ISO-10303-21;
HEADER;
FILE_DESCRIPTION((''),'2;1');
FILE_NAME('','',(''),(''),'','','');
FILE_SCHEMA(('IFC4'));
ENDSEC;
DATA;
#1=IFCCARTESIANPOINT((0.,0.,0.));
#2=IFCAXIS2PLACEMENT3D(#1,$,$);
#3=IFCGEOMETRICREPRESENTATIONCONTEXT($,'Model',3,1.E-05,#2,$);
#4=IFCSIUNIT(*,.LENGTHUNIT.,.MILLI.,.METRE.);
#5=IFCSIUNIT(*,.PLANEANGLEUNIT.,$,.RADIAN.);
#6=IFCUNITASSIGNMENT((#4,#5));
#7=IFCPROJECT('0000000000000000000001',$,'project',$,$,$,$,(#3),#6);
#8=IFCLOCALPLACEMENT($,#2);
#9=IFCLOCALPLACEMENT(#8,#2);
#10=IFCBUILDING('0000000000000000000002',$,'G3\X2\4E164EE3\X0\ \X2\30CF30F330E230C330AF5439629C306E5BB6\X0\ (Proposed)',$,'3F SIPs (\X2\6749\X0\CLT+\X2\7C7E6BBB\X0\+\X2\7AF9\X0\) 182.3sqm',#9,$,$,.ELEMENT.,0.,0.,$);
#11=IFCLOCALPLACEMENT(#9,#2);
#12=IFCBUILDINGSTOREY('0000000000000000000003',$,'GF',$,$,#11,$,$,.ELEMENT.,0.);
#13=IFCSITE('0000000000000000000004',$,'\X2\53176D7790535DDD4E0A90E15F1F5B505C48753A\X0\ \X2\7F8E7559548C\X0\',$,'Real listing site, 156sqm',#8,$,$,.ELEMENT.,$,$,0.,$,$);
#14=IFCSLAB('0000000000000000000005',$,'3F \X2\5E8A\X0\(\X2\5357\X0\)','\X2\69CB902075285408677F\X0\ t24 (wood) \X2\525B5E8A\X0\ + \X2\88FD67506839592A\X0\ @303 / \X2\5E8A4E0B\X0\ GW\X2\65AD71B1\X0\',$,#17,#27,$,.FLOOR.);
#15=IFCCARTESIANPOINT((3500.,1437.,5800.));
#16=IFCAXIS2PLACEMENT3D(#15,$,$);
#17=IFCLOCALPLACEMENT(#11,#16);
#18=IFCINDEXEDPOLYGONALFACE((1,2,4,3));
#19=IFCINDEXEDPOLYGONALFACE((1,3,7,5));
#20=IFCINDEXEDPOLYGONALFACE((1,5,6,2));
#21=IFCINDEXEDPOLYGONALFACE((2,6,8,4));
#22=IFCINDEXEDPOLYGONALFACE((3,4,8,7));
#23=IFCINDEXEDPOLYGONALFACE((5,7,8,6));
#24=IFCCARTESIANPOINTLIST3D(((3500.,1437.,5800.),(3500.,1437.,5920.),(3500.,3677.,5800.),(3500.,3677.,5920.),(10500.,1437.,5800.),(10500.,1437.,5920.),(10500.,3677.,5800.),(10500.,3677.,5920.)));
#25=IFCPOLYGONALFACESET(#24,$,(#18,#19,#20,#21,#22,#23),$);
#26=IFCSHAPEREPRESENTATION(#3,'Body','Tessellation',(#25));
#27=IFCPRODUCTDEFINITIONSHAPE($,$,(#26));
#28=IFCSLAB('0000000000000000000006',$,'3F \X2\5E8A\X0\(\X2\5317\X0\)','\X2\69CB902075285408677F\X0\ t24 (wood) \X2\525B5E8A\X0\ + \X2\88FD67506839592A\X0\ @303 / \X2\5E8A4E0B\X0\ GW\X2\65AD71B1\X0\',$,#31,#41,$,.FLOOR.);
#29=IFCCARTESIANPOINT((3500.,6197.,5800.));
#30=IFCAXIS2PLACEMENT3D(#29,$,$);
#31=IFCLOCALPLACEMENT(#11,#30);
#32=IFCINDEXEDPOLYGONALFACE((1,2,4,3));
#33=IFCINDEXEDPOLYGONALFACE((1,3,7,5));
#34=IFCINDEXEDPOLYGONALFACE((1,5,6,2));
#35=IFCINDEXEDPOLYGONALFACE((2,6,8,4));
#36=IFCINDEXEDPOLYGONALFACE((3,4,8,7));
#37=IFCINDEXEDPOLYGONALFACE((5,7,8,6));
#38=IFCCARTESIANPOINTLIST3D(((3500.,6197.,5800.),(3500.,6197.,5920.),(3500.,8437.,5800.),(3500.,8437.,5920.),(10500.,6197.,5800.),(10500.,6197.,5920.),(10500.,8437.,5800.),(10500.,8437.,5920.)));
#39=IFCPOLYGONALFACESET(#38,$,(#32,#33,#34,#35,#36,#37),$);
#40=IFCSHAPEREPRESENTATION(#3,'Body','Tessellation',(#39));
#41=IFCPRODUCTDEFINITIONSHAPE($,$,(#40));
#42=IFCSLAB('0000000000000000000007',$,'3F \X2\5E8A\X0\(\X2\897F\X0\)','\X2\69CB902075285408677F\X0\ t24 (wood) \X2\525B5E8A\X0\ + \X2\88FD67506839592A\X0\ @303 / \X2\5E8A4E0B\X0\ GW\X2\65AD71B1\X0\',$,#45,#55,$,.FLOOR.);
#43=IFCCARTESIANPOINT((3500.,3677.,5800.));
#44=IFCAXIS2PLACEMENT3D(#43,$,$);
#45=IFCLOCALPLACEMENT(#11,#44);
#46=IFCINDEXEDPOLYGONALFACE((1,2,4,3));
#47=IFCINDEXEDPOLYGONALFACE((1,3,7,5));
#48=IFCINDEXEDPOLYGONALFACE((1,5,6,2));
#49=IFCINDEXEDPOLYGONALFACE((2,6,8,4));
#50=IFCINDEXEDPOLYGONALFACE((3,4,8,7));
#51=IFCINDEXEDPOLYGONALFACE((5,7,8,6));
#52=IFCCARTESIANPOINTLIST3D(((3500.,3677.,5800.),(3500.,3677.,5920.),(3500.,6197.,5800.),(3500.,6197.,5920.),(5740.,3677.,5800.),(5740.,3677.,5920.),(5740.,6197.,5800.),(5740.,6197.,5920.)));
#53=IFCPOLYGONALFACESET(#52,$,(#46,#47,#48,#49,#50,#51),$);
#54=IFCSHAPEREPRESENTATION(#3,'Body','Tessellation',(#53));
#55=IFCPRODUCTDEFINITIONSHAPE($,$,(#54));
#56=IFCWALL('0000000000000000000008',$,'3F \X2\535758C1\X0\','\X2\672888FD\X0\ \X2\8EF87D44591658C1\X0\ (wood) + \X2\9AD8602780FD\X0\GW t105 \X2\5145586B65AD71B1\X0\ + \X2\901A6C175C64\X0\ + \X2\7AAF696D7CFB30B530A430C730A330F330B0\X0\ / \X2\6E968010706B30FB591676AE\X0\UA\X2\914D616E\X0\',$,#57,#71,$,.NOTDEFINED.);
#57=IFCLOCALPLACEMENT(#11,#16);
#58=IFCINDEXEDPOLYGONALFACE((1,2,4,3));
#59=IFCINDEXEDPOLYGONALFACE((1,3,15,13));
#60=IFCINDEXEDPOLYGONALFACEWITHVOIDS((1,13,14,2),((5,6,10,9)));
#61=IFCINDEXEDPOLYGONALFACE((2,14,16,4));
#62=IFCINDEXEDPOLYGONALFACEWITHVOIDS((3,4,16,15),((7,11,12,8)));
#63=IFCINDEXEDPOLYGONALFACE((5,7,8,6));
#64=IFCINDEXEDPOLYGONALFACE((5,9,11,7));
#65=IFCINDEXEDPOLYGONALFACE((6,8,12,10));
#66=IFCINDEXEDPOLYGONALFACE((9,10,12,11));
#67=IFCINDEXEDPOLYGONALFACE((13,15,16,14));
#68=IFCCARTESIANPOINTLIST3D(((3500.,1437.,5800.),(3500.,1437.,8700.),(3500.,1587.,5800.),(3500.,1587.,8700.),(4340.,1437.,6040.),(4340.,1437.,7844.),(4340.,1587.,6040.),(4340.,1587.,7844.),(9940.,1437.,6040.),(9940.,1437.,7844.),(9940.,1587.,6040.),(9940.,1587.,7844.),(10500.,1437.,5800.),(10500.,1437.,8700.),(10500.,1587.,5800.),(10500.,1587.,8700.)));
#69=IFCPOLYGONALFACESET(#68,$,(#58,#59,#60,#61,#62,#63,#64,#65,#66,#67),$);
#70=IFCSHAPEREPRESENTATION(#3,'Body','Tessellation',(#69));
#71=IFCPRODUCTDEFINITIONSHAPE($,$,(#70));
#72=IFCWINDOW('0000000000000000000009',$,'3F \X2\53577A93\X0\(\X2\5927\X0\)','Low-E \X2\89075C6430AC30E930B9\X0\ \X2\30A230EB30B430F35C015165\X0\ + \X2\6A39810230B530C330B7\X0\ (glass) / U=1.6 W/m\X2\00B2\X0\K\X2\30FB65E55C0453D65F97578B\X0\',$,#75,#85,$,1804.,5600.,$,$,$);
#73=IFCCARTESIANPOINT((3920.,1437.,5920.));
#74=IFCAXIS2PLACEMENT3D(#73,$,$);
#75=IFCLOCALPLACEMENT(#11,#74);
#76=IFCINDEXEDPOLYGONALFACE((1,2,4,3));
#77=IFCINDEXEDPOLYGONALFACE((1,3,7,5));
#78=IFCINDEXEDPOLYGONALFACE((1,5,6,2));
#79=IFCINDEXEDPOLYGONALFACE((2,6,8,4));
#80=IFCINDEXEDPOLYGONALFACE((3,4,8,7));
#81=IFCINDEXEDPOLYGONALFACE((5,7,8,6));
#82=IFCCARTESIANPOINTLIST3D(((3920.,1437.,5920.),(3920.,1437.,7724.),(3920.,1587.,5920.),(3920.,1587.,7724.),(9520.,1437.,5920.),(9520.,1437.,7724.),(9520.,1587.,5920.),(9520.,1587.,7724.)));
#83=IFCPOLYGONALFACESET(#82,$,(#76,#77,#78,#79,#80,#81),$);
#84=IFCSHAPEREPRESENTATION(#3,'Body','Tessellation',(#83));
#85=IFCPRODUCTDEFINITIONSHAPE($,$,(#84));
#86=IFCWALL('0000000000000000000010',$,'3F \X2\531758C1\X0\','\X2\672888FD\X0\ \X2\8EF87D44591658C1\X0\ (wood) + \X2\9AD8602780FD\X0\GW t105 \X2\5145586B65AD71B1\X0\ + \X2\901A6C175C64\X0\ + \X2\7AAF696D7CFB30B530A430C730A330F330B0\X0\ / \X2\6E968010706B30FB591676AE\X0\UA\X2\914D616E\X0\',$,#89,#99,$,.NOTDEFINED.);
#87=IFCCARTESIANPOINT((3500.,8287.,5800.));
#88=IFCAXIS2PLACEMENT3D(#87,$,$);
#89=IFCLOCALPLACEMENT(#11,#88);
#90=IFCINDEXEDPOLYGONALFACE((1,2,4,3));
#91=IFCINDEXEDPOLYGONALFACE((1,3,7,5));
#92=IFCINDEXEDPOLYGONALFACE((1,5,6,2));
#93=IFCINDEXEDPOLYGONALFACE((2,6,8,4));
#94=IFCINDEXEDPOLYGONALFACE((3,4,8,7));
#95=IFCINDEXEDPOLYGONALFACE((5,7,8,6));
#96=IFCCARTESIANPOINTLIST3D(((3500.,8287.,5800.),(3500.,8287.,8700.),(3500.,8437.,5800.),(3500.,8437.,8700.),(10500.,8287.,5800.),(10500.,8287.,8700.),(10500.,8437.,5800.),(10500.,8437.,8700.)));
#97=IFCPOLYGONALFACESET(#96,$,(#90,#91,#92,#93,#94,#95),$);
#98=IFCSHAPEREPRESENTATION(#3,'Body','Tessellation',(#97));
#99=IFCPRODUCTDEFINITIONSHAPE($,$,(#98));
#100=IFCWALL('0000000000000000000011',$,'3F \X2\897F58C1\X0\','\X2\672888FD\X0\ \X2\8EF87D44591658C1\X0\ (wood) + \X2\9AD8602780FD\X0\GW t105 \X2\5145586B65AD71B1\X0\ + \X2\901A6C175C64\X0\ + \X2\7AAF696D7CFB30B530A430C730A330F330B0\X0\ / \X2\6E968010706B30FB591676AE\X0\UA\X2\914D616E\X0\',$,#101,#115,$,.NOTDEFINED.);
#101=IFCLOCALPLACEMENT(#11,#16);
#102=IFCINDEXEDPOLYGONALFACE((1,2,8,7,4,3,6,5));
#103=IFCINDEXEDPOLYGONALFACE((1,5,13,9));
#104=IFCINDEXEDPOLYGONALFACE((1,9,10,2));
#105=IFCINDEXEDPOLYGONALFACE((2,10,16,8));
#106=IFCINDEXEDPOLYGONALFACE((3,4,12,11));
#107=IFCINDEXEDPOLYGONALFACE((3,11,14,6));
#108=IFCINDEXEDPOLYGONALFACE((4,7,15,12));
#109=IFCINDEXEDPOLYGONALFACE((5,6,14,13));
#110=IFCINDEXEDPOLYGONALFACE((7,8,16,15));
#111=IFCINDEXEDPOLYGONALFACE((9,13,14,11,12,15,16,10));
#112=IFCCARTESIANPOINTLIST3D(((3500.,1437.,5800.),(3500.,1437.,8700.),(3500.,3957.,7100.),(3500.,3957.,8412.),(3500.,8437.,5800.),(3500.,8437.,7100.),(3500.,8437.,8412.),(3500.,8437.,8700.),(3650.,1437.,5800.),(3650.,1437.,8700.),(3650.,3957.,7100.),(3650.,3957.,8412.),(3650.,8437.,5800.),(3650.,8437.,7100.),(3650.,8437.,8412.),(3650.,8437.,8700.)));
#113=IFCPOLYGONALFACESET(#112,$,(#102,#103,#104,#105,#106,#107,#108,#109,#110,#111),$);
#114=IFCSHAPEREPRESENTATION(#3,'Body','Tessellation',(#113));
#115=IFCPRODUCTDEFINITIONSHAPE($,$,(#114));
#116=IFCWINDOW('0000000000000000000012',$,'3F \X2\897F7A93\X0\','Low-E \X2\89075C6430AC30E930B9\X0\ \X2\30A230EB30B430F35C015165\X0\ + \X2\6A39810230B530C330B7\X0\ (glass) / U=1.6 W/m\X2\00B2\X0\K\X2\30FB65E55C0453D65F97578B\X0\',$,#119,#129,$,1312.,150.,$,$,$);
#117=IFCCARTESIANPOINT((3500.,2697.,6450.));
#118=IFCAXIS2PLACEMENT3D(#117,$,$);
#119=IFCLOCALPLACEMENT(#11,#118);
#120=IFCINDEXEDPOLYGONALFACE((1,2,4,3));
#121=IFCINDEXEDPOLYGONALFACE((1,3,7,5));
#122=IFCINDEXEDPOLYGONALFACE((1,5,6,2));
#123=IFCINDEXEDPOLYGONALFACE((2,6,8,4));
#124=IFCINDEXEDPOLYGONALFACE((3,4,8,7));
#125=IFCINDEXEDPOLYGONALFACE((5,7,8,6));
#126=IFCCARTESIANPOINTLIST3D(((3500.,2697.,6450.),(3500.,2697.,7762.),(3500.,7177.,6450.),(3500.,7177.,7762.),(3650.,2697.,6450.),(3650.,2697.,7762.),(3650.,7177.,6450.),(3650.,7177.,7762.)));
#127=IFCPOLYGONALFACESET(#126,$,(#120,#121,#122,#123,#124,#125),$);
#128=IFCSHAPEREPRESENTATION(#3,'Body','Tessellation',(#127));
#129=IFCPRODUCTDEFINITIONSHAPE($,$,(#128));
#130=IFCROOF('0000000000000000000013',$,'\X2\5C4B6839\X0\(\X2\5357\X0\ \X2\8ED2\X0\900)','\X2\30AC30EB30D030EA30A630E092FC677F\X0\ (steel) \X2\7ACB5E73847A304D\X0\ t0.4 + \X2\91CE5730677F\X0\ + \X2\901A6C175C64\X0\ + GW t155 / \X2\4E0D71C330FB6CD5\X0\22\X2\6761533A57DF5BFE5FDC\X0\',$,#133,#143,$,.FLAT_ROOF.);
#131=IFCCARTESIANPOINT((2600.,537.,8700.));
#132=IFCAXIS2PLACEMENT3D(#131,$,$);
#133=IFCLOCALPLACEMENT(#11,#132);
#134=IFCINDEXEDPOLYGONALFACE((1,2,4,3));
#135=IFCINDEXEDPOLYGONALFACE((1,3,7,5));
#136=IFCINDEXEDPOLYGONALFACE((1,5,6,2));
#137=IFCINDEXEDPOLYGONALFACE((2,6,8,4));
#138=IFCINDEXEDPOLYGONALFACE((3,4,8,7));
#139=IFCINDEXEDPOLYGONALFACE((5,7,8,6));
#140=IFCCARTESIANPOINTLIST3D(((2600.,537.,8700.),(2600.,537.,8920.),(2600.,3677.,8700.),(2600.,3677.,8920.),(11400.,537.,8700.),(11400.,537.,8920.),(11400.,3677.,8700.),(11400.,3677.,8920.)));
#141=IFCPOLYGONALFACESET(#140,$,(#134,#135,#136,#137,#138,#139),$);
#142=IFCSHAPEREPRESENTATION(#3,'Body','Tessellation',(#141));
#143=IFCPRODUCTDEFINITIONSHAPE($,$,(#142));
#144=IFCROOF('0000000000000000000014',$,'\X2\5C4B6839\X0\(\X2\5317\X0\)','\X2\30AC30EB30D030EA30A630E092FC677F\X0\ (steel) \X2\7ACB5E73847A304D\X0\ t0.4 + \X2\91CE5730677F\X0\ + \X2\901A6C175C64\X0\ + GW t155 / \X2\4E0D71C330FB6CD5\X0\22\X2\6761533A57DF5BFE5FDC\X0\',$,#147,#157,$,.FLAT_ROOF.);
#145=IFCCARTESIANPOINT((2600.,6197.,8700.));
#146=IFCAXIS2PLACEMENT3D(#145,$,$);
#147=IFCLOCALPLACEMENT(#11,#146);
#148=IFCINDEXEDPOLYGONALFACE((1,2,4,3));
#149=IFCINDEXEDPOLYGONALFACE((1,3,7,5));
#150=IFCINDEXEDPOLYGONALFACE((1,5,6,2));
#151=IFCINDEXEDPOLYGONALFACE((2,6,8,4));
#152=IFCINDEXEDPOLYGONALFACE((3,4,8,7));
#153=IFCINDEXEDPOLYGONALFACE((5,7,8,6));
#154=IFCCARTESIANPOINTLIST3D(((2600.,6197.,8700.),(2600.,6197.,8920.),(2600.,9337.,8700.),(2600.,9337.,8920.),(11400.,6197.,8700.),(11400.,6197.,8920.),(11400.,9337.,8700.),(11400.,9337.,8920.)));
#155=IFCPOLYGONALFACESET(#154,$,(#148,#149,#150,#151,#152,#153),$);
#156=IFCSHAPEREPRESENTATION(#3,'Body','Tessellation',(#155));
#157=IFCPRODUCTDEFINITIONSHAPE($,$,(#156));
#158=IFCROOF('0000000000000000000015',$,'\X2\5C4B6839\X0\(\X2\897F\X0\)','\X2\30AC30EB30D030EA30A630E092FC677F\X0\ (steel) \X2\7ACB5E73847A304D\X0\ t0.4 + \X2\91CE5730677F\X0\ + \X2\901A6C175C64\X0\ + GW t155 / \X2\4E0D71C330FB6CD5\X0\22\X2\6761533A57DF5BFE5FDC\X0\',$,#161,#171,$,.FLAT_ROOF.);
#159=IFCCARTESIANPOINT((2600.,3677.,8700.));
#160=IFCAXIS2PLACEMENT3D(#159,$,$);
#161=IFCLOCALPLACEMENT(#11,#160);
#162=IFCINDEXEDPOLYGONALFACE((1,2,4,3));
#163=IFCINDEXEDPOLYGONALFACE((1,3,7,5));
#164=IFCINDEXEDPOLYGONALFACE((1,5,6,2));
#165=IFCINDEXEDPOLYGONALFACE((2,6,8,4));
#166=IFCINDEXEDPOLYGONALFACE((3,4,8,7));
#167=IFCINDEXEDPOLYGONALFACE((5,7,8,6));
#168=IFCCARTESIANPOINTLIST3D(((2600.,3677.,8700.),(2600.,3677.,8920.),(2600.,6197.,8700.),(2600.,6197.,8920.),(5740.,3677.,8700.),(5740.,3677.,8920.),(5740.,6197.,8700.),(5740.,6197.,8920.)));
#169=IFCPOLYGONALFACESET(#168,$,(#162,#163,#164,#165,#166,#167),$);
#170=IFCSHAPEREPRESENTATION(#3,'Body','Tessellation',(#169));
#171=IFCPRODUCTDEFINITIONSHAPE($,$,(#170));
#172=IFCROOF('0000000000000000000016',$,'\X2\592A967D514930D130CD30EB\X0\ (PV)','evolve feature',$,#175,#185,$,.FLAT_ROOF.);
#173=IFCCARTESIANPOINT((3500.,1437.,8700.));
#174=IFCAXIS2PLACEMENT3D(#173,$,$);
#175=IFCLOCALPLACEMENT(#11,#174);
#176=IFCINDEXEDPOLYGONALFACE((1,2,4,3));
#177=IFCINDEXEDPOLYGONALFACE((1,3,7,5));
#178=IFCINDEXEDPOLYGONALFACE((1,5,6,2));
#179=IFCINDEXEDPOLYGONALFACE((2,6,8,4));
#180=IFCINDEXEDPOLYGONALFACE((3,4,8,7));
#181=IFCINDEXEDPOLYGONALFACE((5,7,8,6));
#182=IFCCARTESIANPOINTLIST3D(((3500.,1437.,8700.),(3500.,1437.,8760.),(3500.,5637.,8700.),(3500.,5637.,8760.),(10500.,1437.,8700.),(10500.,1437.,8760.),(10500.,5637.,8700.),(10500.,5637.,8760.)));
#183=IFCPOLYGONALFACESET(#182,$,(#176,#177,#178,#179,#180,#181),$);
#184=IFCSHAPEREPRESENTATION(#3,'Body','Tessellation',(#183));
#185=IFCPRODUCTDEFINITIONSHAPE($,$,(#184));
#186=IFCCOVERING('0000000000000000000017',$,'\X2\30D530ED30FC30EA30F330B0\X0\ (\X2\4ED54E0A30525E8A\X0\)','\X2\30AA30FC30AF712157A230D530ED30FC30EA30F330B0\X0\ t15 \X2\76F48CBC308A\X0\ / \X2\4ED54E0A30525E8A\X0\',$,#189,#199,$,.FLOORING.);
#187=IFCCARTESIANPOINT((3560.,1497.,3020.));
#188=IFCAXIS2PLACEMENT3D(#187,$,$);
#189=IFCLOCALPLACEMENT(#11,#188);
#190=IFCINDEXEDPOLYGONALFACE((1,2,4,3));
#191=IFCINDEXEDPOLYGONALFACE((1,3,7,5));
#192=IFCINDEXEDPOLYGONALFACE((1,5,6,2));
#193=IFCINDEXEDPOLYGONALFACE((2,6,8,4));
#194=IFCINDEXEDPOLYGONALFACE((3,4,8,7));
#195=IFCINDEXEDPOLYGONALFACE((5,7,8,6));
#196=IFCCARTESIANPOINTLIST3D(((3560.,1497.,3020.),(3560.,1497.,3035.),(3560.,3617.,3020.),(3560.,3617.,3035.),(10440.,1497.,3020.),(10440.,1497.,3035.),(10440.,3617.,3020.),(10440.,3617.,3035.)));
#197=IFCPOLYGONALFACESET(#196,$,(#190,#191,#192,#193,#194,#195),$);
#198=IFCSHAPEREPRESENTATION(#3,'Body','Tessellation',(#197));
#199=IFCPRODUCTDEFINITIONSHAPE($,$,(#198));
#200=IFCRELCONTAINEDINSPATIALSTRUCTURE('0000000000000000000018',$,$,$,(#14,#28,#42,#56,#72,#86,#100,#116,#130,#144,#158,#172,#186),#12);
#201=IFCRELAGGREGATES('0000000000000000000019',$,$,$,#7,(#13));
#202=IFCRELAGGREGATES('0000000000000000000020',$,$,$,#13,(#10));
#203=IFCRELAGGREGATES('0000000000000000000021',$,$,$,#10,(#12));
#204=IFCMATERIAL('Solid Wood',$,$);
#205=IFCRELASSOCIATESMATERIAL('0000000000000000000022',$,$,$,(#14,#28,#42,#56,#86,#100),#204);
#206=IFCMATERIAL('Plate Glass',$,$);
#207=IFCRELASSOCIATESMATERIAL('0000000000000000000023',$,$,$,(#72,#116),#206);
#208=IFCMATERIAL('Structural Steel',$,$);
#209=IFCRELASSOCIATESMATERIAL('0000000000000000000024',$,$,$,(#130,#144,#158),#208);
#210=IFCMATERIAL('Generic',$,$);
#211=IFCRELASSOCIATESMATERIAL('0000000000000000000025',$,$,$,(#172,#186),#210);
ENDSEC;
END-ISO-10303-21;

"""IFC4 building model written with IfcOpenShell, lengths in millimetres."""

from ifc_helpers import new_model, si_unit, frame, frame_2d, origin, place, context, project, spatial, rectangle, extrude, material, element, fill, save


model = new_model("IFC4")

# Units and contexts
model_context = context("Model", 3, precision=1e-05, world=origin())
ifc_project = project(units=[si_unit("LENGTHUNIT", "METRE", prefix="MILLI"), si_unit("PLANEANGLEUNIT", "RADIAN")], contexts=[model_context])

# Site, building, storey
site_placement = place(None, origin())
site = spatial("IfcSite", under=ifc_project, at=site_placement, Name="北海道川上郡弟子屈町 美留和", ObjectType="Real listing site, 156sqm", CompositionType="ELEMENT", RefElevation=0.0)
building_placement = place(site_placement, origin())
building = spatial("IfcBuilding", under=site, at=building_placement, Name="G3世代 ハンモック吹抜の家 (Proposed)", ObjectType="3F SIPs (杉CLT+籾殻+竹) 182.3sqm", CompositionType="ELEMENT", ElevationOfRefHeight=0.0, ElevationOfTerrain=0.0)
storey_placement = place(building_placement, origin())
storey = spatial("IfcBuildingStorey", under=building, at=storey_placement, Name="GF", CompositionType="ELEMENT", Elevation=0.0)

# Slabs
ifc_material_1 = material(Name="Solid Wood")
slab_1_placement = place(storey_placement, frame((3500.0, 1437.0, 5800.0)))
element("IfcSlab", 1, at=slab_1_placement, inside=storey, material=ifc_material_1, Name="3F 床(南)", Description="構造用合板 t24 (wood) 剛床 + 製材根太 @303 / 床下 GW断熱", PredefinedType="FLOOR", context=model_context, shape_type="SweptSolid", body=[
    extrude(rectangle(XDim=7000.0, YDim=2240.0, at=frame_2d((3500.0, 1120.0))), frame((3500.0, 1437.0, 5800.0)), (0.0, 0.0, 1.0), 120.0),
])
slab_2_placement = place(storey_placement, frame((3500.0, 6197.0, 5800.0)))
element("IfcSlab", 2, at=slab_2_placement, inside=storey, material=ifc_material_1, Name="3F 床(北)", Description="構造用合板 t24 (wood) 剛床 + 製材根太 @303 / 床下 GW断熱", PredefinedType="FLOOR", context=model_context, shape_type="SweptSolid", body=[
    extrude(rectangle(XDim=7000.0, YDim=2240.0, at=frame_2d((3500.0, 1120.0))), frame((3500.0, 6197.0, 5800.0)), (0.0, 0.0, 1.0), 120.0),
])
slab_3_placement = place(storey_placement, frame((3500.0, 3677.0, 5800.0)))
element("IfcSlab", 3, at=slab_3_placement, inside=storey, material=ifc_material_1, Name="3F 床(西)", Description="構造用合板 t24 (wood) 剛床 + 製材根太 @303 / 床下 GW断熱", PredefinedType="FLOOR", context=model_context, shape_type="SweptSolid", body=[
    extrude(rectangle(XDim=2240.0, YDim=2520.0, at=frame_2d((1120.0, 1260.0))), frame((3500.0, 3677.0, 5800.0)), (0.0, 0.0, 1.0), 120.0),
])

# Wall, opening, window
wall_1_placement = place(storey_placement, frame((3500.0, 1437.0, 5800.0)))
wall_1 = element("IfcWall", 4, at=wall_1_placement, inside=storey, material=ifc_material_1, Name="3F 南壁", Description="木製 軸組外壁 (wood) + 高性能GW t105 充填断熱 + 通気層 + 窯業系サイディング / 準耐火・外皮UA配慮", PredefinedType="NOTDEFINED", context=model_context, shape_type="SweptSolid", body=[
    extrude(rectangle(XDim=7000.0, YDim=150.0, at=frame_2d((3500.0, 75.0))), frame((3500.0, 1437.0, 5800.0)), (0.0, 0.0, 1.0), 2900.0),
])
opening_1_placement = place(storey_placement, frame((3920.0, 1437.0, 5920.0)))
opening_1 = element("IfcOpeningElement", 5, at=opening_1_placement, cuts=wall_1, PredefinedType="NOTDEFINED", context=model_context, shape_type="SweptSolid", body=[
    extrude(rectangle(XDim=5600.0, YDim=150.0, at=frame_2d((2800.0, 75.0))), frame((3920.0, 1437.0, 5920.0)), (0.0, 0.0, 1.0), 1804.0),
])
ifc_material_2 = material(Name="Plate Glass")
window_1_placement = place(storey_placement, frame((3920.0, 1437.0, 5920.0)))
window_1 = element("IfcWindow", 6, at=window_1_placement, inside=storey, material=ifc_material_2, Name="3F 南窓(大)", Description="Low-E 複層ガラス アルゴン封入 + 樹脂サッシ (glass) / U=1.6 W/m²K・日射取得型", OverallHeight=1804.0, OverallWidth=5600.0, context=model_context, shape_type="SweptSolid", body=[
    extrude(rectangle(XDim=5600.0, YDim=150.0, at=frame_2d((2800.0, 75.0))), frame((3920.0, 1437.0, 5920.0)), (0.0, 0.0, 1.0), 1804.0),
])
fill(opening_1, window_1)

# Wall
wall_2_placement = place(storey_placement, frame((3500.0, 8287.0, 5800.0)))
element("IfcWall", 7, at=wall_2_placement, inside=storey, material=ifc_material_1, Name="3F 北壁", Description="木製 軸組外壁 (wood) + 高性能GW t105 充填断熱 + 通気層 + 窯業系サイディング / 準耐火・外皮UA配慮", PredefinedType="NOTDEFINED", context=model_context, shape_type="SweptSolid", body=[
    extrude(rectangle(XDim=7000.0, YDim=150.0, at=frame_2d((3500.0, 75.0))), frame((3500.0, 8287.0, 5800.0)), (0.0, 0.0, 1.0), 2900.0),
])

# Wall, opening, window
wall_3_placement = place(storey_placement, frame((3500.0, 1437.0, 5800.0)))
wall_3 = element("IfcWall", 8, at=wall_3_placement, inside=storey, material=ifc_material_1, Name="3F 西壁", Description="木製 軸組外壁 (wood) + 高性能GW t105 充填断熱 + 通気層 + 窯業系サイディング / 準耐火・外皮UA配慮", PredefinedType="NOTDEFINED", context=model_context, shape_type="SweptSolid", body=[
    extrude(rectangle(XDim=150.0, YDim=7000.0, at=frame_2d((75.0, 3500.0))), frame((3500.0, 1437.0, 5800.0)), (0.0, 0.0, 1.0), 2900.0),
])
opening_2_placement = place(storey_placement, frame((3500.0, 2697.0, 6450.0)))
opening_2 = element("IfcOpeningElement", 9, at=opening_2_placement, cuts=wall_3, PredefinedType="NOTDEFINED", context=model_context, shape_type="SweptSolid", body=[
    extrude(rectangle(XDim=150.0, YDim=4480.0, at=frame_2d((75.0, 2240.0))), frame((3500.0, 2697.0, 6450.0)), (0.0, 0.0, 1.0), 1312.0),
])
window_2_placement = place(storey_placement, frame((3500.0, 2697.0, 6450.0)))
window_2 = element("IfcWindow", 10, at=window_2_placement, inside=storey, material=ifc_material_2, Name="3F 西窓", Description="Low-E 複層ガラス アルゴン封入 + 樹脂サッシ (glass) / U=1.6 W/m²K・日射取得型", OverallHeight=1312.0, OverallWidth=150.0, context=model_context, shape_type="SweptSolid", body=[
    extrude(rectangle(XDim=150.0, YDim=4480.0, at=frame_2d((75.0, 2240.0))), frame((3500.0, 2697.0, 6450.0)), (0.0, 0.0, 1.0), 1312.0),
])
fill(opening_2, window_2)

# Roofs
ifc_material_3 = material(Name="Structural Steel")
roof_1_placement = place(storey_placement, frame((2600.0, 537.0, 8700.0)))
element("IfcRoof", 11, at=roof_1_placement, inside=storey, material=ifc_material_3, Name="屋根(南 軒900)", Description="ガルバリウム鋼板 (steel) 立平葺き t0.4 + 野地板 + 通気層 + GW t155 / 不燃・法22条区域対応", PredefinedType="FLAT_ROOF", context=model_context, shape_type="SweptSolid", body=[
    extrude(rectangle(XDim=8800.0, YDim=3140.0, at=frame_2d((4400.0, 1570.0))), frame((2600.0, 537.0, 8700.0)), (0.0, 0.0, 1.0), 220.0),
])
roof_2_placement = place(storey_placement, frame((2600.0, 6197.0, 8700.0)))
element("IfcRoof", 12, at=roof_2_placement, inside=storey, material=ifc_material_3, Name="屋根(北)", Description="ガルバリウム鋼板 (steel) 立平葺き t0.4 + 野地板 + 通気層 + GW t155 / 不燃・法22条区域対応", PredefinedType="FLAT_ROOF", context=model_context, shape_type="SweptSolid", body=[
    extrude(rectangle(XDim=8800.0, YDim=3140.0, at=frame_2d((4400.0, 1570.0))), frame((2600.0, 6197.0, 8700.0)), (0.0, 0.0, 1.0), 220.0),
])
roof_3_placement = place(storey_placement, frame((2600.0, 3677.0, 8700.0)))
element("IfcRoof", 13, at=roof_3_placement, inside=storey, material=ifc_material_3, Name="屋根(西)", Description="ガルバリウム鋼板 (steel) 立平葺き t0.4 + 野地板 + 通気層 + GW t155 / 不燃・法22条区域対応", PredefinedType="FLAT_ROOF", context=model_context, shape_type="SweptSolid", body=[
    extrude(rectangle(XDim=3140.0, YDim=2520.0, at=frame_2d((1570.0, 1260.0))), frame((2600.0, 3677.0, 8700.0)), (0.0, 0.0, 1.0), 220.0),
])
ifc_material_4 = material(Name="Generic")
roof_4_placement = place(storey_placement, frame((3500.0, 1437.0, 8700.0)))
element("IfcRoof", 14, at=roof_4_placement, inside=storey, material=ifc_material_4, Name="太陽光パネル (PV)", Description="evolve feature", PredefinedType="FLAT_ROOF", context=model_context, shape_type="SweptSolid", body=[
    extrude(rectangle(XDim=7000.0, YDim=4200.0, at=frame_2d((3500.0, 2100.0))), frame((3500.0, 1437.0, 8700.0)), (0.0, 0.0, 1.0), 60.0),
])

# Covering
covering_1_placement = place(storey_placement, frame((3560.0, 1497.0, 3020.0)))
element("IfcCovering", 15, at=covering_1_placement, inside=storey, material=ifc_material_4, Name="フローリング (仕上げ床)", Description="オーク無垢フローリング t15 直貼り / 仕上げ床", PredefinedType="FLOORING", context=model_context, shape_type="SweptSolid", body=[
    extrude(rectangle(XDim=6880.0, YDim=2120.0, at=frame_2d((3440.0, 1060.0))), frame((3560.0, 1497.0, 3020.0)), (0.0, 0.0, 1.0), 15.0),
])

save(model, "model.ifc")
